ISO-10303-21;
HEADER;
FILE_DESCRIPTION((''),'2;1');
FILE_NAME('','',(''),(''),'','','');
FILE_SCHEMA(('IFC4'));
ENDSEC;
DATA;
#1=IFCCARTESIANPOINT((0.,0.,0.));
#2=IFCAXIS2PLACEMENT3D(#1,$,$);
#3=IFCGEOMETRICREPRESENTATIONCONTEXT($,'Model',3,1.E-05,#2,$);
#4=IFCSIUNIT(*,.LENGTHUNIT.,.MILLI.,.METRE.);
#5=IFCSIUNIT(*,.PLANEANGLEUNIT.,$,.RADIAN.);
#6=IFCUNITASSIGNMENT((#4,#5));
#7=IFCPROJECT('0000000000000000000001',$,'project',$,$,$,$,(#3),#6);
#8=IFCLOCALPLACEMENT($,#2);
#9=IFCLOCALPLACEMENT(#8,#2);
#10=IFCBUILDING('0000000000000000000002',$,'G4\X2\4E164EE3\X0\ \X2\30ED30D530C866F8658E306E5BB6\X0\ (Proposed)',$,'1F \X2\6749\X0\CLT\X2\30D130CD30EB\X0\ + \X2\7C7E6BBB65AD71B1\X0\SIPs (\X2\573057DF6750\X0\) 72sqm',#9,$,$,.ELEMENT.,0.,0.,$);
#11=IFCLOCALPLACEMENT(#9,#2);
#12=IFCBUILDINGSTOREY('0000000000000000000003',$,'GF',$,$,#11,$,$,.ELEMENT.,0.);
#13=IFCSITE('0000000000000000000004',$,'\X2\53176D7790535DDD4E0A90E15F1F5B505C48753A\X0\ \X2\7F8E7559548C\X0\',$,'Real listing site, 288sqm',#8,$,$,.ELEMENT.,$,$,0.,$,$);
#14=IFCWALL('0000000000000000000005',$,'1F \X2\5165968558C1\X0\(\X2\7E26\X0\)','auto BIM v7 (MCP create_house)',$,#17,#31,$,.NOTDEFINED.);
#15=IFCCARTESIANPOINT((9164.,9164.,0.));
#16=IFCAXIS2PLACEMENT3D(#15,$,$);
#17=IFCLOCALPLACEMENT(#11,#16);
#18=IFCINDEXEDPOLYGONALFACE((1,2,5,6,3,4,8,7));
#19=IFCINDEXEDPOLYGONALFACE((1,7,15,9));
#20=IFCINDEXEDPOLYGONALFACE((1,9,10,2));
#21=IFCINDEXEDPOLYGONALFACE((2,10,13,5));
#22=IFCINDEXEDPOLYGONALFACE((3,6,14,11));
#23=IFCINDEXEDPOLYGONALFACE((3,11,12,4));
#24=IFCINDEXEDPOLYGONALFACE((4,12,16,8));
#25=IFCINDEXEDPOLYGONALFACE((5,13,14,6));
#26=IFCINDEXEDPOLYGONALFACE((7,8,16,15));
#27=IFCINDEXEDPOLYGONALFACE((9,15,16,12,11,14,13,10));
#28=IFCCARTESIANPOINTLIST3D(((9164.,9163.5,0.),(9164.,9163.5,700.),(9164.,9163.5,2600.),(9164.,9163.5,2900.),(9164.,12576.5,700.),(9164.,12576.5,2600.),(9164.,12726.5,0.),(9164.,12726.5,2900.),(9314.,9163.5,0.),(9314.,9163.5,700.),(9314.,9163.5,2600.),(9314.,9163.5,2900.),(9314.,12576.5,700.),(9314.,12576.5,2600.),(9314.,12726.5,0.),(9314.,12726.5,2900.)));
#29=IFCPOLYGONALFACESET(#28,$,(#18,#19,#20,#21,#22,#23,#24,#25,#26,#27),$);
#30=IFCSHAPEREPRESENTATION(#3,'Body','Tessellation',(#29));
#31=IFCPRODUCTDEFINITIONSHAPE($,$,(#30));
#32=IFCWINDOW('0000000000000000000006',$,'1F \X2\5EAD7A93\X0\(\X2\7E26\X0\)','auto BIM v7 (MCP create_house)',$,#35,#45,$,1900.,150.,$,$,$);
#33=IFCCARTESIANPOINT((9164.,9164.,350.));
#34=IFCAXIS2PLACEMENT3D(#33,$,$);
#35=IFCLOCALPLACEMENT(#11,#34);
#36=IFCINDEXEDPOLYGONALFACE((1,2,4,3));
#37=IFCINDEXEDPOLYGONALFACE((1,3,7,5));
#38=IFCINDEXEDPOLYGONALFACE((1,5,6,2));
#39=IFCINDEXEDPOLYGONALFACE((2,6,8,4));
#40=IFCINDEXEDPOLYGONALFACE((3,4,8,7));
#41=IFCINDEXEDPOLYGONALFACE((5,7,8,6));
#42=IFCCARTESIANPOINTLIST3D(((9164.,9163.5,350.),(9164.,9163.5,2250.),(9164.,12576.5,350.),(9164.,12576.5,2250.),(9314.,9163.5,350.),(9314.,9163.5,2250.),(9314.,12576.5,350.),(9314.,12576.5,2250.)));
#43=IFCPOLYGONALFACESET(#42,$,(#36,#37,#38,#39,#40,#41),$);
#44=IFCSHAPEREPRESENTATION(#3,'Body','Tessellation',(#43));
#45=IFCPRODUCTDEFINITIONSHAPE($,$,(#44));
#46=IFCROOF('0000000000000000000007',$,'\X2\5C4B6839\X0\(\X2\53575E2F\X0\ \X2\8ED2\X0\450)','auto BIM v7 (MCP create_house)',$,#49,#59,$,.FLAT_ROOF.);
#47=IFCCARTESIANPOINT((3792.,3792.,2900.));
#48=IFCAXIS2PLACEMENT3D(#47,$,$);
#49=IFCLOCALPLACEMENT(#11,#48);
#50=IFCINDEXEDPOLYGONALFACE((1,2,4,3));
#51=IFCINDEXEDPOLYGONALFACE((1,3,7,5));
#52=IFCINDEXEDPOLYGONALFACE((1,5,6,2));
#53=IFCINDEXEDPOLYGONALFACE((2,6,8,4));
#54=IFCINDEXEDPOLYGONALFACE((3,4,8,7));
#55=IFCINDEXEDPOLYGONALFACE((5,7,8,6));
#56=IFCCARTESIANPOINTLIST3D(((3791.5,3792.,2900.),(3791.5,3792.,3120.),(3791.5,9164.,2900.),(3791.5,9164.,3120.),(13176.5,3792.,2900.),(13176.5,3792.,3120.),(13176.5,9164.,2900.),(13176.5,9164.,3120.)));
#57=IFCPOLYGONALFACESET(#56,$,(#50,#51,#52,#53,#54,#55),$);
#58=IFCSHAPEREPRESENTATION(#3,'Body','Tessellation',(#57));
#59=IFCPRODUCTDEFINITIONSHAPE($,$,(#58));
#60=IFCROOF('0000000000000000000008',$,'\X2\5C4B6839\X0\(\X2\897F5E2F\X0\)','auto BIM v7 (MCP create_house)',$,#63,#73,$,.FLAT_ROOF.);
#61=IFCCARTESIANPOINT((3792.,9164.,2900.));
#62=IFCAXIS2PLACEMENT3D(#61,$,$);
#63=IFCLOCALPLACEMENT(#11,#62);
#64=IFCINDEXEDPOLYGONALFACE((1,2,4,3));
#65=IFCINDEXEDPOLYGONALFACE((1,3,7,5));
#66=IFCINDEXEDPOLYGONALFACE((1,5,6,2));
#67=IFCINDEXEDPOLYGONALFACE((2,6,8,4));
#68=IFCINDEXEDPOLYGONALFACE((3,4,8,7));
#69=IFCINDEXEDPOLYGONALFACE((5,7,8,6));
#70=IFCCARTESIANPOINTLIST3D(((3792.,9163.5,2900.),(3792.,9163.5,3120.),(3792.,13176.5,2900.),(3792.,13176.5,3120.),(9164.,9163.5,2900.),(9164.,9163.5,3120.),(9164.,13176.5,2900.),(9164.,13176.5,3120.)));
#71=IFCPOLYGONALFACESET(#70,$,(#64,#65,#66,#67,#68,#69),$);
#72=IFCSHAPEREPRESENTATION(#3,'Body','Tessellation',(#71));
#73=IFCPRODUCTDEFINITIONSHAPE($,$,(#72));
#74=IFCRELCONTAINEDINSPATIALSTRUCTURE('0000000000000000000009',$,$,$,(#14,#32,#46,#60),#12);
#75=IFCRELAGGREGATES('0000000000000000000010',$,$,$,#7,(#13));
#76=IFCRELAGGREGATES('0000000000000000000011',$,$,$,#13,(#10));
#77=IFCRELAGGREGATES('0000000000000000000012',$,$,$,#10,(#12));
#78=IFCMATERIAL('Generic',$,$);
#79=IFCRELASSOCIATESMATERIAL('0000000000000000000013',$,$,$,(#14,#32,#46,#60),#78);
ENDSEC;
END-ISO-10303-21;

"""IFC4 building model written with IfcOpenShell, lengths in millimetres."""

from ifc_helpers import new_model, si_unit, frame, frame_2d, origin, place, context, project, spatial, rectangle, extrude, material, element, fill, save


model = new_model("IFC4")

# Units and contexts
model_context = context("Model", 3, precision=1e-05, world=origin())
ifc_project = project(units=[si_unit("LENGTHUNIT", "METRE", prefix="MILLI"), si_unit("PLANEANGLEUNIT", "RADIAN")], contexts=[model_context])

# Site, building, storey
site_placement = place(None, origin())
site = spatial("IfcSite", under=ifc_project, at=site_placement, Name="北海道川上郡弟子屈町 美留和", ObjectType="Real listing site, 288sqm", CompositionType="ELEMENT", RefElevation=0.0)
building_placement = place(site_placement, origin())
building = spatial("IfcBuilding", under=site, at=building_placement, Name="G4世代 ロフト書斎の家 (Proposed)", ObjectType="1F 杉CLTパネル + 籾殻断熱SIPs (地域材) 72sqm", CompositionType="ELEMENT", ElevationOfRefHeight=0.0, ElevationOfTerrain=0.0)
storey_placement = place(building_placement, origin())
storey = spatial("IfcBuildingStorey", under=building, at=storey_placement, Name="GF", CompositionType="ELEMENT", Elevation=0.0)

# Shared definitions
ifc_material = material(Name="Generic")

# Wall, opening, window
wall_1_placement = place(storey_placement, frame((9164.0, 9164.0, 0.0)))
wall_1 = element("IfcWall", 1, at=wall_1_placement, inside=storey, material=ifc_material, Name="1F 入隅壁(縦)", Description="auto BIM v7 (MCP create_house)", PredefinedType="NOTDEFINED", context=model_context, shape_type="SweptSolid", body=[
    extrude(rectangle(XDim=150.0, YDim=3563.0, at=frame_2d((75.0, 1781.0))), frame((9164.0, 9164.0, 0.0)), (0.0, 0.0, 1.0), 2900.0),
])
opening_1_placement = place(storey_placement, frame((9164.0, 9164.0, 350.0)))
opening_1 = element("IfcOpeningElement", 2, at=opening_1_placement, cuts=wall_1, PredefinedType="NOTDEFINED", context=model_context, shape_type="SweptSolid", body=[
    extrude(rectangle(XDim=150.0, YDim=3413.0, at=frame_2d((75.0, 1706.0))), frame((9164.0, 9164.0, 350.0)), (0.0, 0.0, 1.0), 1900.0),
])
window_1_placement = place(storey_placement, frame((9164.0, 9164.0, 350.0)))
window_1 = element("IfcWindow", 3, at=window_1_placement, inside=storey, material=ifc_material, Name="1F 庭窓(縦)", Description="auto BIM v7 (MCP create_house)", OverallHeight=1900.0, OverallWidth=150.0, context=model_context, shape_type="SweptSolid", body=[
    extrude(rectangle(XDim=150.0, YDim=3413.0, at=frame_2d((75.0, 1706.0))), frame((9164.0, 9164.0, 350.0)), (0.0, 0.0, 1.0), 1900.0),
])
fill(opening_1, window_1)

# Roofs
roof_1_placement = place(storey_placement, frame((3792.0, 3792.0, 2900.0)))
element("IfcRoof", 4, at=roof_1_placement, inside=storey, material=ifc_material, Name="屋根(南帯 軒450)", Description="auto BIM v7 (MCP create_house)", PredefinedType="FLAT_ROOF", context=model_context, shape_type="SweptSolid", body=[
    extrude(rectangle(XDim=9385.0, YDim=5372.0, at=frame_2d((4692.0, 2686.0))), frame((3792.0, 3792.0, 2900.0)), (0.0, 0.0, 1.0), 220.0),
])
roof_2_placement = place(storey_placement, frame((3792.0, 9164.0, 2900.0)))
element("IfcRoof", 5, at=roof_2_placement, inside=storey, material=ifc_material, Name="屋根(西帯)", Description="auto BIM v7 (MCP create_house)", PredefinedType="FLAT_ROOF", context=model_context, shape_type="SweptSolid", body=[
    extrude(rectangle(XDim=5372.0, YDim=4013.0, at=frame_2d((2686.0, 2006.0))), frame((3792.0, 9164.0, 2900.0)), (0.0, 0.0, 1.0), 220.0),
])

save(model, "model.ifc")
